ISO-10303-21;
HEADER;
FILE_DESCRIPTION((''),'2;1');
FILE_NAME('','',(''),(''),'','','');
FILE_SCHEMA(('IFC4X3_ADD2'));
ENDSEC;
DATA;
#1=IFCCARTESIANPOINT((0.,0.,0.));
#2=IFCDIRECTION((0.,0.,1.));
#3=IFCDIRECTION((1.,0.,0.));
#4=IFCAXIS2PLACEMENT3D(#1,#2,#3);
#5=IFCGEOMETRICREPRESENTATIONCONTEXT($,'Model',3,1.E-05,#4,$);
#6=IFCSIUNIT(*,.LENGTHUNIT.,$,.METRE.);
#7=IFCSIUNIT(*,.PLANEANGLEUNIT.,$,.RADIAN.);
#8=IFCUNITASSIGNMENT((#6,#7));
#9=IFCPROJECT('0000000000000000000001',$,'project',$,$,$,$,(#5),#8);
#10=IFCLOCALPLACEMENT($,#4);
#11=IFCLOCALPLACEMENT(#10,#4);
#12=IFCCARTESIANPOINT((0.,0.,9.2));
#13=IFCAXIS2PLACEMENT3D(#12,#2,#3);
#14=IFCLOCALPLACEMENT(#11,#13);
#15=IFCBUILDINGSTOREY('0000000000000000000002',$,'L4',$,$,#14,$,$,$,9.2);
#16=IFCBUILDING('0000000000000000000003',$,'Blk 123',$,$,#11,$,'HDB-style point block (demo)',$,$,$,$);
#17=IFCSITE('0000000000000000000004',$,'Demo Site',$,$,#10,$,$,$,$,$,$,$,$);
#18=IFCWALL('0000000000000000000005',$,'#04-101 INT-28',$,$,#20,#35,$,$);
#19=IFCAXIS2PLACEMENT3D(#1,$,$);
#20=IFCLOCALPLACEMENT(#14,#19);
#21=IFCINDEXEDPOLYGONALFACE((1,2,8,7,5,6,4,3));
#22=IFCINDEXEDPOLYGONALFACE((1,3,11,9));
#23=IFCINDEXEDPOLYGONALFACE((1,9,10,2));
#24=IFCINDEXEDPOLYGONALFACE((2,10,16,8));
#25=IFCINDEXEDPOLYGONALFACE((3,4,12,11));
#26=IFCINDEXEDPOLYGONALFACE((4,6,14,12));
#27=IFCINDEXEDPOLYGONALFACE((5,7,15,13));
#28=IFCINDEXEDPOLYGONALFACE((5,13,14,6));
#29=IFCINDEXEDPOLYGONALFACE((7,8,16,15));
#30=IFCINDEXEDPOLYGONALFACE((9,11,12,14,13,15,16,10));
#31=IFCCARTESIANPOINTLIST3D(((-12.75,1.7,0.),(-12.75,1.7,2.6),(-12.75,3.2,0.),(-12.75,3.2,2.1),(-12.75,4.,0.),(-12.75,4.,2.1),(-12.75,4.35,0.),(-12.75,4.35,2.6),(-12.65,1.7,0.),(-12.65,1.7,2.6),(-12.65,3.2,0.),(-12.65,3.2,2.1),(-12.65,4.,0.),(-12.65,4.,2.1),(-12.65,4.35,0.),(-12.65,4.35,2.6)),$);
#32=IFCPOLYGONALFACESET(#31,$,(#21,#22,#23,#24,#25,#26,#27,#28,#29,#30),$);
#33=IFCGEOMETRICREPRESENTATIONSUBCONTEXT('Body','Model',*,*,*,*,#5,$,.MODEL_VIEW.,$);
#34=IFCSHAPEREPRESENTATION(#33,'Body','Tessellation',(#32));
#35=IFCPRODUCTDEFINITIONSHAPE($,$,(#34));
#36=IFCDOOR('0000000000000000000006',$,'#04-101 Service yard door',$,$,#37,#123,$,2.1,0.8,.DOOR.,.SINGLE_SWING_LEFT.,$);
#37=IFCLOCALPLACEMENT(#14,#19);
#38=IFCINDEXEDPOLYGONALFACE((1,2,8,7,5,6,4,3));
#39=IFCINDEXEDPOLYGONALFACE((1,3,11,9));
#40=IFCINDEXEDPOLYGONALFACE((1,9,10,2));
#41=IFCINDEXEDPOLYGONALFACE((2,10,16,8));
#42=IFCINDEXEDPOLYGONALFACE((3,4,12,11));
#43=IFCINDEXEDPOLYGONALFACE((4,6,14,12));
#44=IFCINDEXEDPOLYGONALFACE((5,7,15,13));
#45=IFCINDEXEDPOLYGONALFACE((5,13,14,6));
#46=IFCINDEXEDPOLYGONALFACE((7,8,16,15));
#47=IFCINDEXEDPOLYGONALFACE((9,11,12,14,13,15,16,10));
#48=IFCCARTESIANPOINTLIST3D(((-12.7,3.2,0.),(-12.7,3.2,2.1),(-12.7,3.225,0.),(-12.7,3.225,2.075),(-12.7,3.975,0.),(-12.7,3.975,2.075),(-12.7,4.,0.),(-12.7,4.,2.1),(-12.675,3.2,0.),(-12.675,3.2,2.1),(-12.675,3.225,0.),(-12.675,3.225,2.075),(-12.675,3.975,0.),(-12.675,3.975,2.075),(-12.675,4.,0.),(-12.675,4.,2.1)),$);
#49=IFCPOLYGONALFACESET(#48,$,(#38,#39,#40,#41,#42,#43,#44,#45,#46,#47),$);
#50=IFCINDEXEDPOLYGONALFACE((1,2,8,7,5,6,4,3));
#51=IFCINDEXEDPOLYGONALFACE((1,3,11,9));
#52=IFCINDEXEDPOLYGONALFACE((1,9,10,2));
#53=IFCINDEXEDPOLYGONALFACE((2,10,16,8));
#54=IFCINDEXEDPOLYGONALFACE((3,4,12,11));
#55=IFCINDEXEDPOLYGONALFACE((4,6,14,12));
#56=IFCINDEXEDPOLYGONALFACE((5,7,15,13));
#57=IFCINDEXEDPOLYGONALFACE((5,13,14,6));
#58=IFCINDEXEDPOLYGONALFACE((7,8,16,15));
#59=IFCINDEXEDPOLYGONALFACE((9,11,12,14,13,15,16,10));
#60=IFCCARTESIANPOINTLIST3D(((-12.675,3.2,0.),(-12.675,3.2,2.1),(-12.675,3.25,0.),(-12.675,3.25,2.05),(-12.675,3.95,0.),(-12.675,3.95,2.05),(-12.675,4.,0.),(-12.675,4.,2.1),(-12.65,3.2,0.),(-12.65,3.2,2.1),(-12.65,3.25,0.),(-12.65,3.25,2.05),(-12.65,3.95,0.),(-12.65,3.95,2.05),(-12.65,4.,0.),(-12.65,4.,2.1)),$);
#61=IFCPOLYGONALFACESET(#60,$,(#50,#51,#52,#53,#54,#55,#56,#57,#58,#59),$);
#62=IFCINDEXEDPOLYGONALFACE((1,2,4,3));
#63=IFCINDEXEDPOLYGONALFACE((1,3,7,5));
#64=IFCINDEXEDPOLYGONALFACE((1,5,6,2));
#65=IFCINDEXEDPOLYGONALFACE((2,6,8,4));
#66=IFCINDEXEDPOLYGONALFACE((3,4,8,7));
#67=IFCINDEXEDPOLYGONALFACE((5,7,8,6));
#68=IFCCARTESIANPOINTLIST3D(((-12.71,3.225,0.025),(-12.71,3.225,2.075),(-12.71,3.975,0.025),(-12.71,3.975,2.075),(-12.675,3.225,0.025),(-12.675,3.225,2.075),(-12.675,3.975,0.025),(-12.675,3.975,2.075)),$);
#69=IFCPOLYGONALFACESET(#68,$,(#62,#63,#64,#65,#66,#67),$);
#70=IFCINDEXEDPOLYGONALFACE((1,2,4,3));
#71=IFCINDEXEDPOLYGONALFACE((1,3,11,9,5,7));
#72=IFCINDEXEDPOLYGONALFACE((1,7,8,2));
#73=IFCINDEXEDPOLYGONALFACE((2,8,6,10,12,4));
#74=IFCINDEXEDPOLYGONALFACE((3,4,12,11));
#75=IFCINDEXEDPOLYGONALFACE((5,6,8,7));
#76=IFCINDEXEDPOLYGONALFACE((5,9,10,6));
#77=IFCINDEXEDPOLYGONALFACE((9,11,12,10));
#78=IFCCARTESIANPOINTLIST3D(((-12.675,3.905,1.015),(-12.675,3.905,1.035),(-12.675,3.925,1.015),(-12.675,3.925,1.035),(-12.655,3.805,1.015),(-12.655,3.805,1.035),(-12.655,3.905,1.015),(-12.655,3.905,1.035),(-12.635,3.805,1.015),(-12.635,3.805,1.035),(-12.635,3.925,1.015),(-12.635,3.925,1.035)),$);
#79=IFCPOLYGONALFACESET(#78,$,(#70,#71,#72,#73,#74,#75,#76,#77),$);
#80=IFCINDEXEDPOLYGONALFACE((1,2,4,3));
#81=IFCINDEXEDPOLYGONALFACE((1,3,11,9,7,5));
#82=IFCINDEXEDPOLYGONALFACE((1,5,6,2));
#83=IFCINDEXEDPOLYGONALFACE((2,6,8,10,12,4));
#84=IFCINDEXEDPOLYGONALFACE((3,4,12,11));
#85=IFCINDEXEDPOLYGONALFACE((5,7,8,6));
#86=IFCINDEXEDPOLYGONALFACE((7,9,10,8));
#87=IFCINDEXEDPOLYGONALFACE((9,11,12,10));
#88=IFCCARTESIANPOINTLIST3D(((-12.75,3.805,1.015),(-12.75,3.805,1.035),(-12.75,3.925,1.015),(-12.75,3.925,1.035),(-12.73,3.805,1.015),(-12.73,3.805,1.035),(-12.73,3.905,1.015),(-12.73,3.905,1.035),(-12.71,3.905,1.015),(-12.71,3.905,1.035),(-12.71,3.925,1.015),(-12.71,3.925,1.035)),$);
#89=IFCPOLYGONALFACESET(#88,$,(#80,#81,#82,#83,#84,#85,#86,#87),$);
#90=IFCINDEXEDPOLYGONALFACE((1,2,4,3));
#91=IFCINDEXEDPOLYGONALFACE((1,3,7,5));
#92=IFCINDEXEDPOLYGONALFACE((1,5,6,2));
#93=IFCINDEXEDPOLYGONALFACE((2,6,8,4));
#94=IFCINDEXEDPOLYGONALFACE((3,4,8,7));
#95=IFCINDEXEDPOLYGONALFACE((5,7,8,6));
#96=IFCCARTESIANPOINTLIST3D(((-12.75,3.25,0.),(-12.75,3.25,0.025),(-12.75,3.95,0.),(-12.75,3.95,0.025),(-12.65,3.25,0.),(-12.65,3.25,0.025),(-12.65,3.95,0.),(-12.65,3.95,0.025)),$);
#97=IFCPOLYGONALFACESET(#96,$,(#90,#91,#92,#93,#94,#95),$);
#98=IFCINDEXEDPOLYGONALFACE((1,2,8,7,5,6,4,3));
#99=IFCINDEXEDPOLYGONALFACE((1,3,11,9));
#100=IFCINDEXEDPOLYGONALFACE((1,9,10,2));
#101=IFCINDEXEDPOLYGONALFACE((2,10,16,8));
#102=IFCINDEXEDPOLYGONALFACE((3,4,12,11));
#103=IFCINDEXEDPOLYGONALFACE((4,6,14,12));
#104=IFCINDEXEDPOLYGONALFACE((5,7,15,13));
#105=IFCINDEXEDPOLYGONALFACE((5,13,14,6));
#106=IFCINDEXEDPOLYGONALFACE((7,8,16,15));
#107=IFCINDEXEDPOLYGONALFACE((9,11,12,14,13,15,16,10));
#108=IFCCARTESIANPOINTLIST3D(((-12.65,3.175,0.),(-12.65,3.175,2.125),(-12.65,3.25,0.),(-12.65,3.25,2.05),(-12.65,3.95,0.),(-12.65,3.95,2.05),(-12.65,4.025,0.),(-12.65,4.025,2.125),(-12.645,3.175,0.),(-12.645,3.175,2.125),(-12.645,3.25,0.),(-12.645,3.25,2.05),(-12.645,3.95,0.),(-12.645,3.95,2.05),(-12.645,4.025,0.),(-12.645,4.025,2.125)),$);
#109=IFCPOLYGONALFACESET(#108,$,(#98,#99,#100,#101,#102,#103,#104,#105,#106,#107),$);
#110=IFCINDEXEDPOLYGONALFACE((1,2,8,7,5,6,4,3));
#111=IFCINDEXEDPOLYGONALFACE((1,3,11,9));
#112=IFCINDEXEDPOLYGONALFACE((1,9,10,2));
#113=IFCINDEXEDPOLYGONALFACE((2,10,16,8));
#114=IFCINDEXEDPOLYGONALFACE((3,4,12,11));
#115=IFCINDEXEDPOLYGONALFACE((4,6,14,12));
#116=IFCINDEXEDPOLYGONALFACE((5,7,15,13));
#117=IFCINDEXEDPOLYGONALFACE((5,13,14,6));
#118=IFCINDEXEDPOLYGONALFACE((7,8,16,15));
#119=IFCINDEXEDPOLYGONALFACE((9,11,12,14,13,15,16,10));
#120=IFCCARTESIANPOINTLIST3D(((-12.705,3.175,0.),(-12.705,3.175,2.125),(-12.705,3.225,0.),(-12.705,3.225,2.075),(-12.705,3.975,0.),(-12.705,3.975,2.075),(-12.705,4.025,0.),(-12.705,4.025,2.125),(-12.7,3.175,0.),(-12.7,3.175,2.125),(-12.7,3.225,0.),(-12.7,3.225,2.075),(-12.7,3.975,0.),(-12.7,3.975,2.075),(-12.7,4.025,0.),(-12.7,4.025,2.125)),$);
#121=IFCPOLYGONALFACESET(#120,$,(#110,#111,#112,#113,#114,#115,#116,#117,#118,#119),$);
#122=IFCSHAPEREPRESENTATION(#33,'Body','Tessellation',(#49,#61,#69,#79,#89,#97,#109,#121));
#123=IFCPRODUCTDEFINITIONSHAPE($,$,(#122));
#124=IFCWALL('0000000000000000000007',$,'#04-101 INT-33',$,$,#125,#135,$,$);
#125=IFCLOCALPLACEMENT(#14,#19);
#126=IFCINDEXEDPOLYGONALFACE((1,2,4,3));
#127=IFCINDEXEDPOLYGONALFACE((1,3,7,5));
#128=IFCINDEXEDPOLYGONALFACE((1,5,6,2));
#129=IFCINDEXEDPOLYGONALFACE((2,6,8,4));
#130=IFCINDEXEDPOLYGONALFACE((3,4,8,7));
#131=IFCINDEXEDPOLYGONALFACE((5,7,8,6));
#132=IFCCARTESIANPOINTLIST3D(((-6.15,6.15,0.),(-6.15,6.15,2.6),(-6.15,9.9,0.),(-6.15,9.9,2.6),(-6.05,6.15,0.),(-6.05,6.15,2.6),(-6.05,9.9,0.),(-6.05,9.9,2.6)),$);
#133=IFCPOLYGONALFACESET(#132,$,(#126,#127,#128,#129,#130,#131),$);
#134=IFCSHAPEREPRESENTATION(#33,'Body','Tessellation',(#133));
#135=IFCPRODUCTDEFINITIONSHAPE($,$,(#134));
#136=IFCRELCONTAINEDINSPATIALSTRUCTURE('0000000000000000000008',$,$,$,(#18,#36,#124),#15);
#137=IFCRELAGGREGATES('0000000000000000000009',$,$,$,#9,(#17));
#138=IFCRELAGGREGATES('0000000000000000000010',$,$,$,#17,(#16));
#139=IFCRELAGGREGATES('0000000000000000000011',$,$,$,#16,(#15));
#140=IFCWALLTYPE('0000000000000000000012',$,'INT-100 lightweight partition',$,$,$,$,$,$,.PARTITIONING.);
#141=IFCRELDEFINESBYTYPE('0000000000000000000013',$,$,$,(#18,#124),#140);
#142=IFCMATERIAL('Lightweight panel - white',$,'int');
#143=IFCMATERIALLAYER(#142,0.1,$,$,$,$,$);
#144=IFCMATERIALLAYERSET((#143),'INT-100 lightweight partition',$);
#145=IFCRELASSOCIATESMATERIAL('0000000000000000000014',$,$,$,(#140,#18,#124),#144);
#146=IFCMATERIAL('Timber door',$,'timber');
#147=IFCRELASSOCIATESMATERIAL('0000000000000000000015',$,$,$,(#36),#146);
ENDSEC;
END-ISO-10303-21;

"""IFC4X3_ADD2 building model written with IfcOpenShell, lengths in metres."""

from ifc_helpers import new_model, si_unit, frame, origin_with_axes, place, context, subcontext, project, spatial, line, indexed_curve, outline, extrude, material, layer, layer_set, layer_usage, type_object, element, fill, save


model = new_model("IFC4X3_ADD2")

# Units and contexts
model_context = context("Model", 3, precision=1e-05, world=origin_with_axes())
body_context = subcontext(model_context, "Body", "Model", "MODEL_VIEW")
ifc_project = project(units=[si_unit("LENGTHUNIT", "METRE"), si_unit("PLANEANGLEUNIT", "RADIAN")], contexts=[model_context])

# Site, building, storey
site_placement = place(None, origin_with_axes())
site = spatial("IfcSite", under=ifc_project, at=site_placement, Name="Demo Site")
building_placement = place(site_placement, origin_with_axes())
building = spatial("IfcBuilding", under=site, at=building_placement, Name="Blk 123", LongName="HDB-style point block (demo)")
storey_placement = place(building_placement, frame((0.0, 0.0, 9.2), z_axis=(0.0, 0.0, 1.0), x_axis=(1.0, 0.0, 0.0)))
storey = spatial("IfcBuildingStorey", under=building, at=storey_placement, Name="L4", Elevation=9.2)

# Shared definitions
ifc_material_1 = material(Name="Timber door", Category="timber")

# Shared definitions
ifc_material_2 = material(Name="Lightweight panel - white", Category="int")
ifc_layer_1 = layer(ifc_material_2, 0.1)
ifc_layer_set_1 = layer_set([ifc_layer_1], Name="INT-100 lightweight partition")
ifc_layer_usage_1 = layer_usage(ifc_layer_set_1, "AXIS2", "POSITIVE", -0.05)
wall_type_1 = type_object("IfcWallType", Name="INT-100 lightweight partition", PredefinedType="PARTITIONING", material=ifc_layer_set_1)

# Wall, opening, door
wall_1_placement = place(storey_placement, frame((-12.7, 1.7, 0.0), z_axis=(0.0, 0.0, 1.0), x_axis=(0.0, 1.0, 0.0)))
wall_1 = element("IfcWall", 1, at=wall_1_placement, inside=storey, type_object=wall_type_1, material=ifc_layer_usage_1, Name="#04-101 INT-28", context=body_context, shape_type="SweptSolid", body=[
    extrude(outline(indexed_curve([(0.0, 0.0), (0.0, 0.1), (2.65, 0.1), (2.65, 0.0), (0.0, 0.0)], self_intersect=False)), frame((0.0, -0.05, 0.0), z_axis=(0.0, 0.0, 1.0), x_axis=(1.0, 0.0, 0.0)), (0.0, 0.0, 1.0), 2.6),
])
opening_1_placement = place(wall_1_placement, frame((1.5, -0.15, 0.0), z_axis=(0.0, 0.0, 1.0), x_axis=(1.0, 0.0, 0.0)))
opening_1 = element("IfcOpeningElement", 2, at=opening_1_placement, cuts=wall_1, context=body_context, shape_type="SweptSolid", body=[
    extrude(outline(indexed_curve([(0.0, 0.0), (0.0, 0.3), (0.8, 0.3), (0.8, 0.0), (0.0, 0.0)], self_intersect=False)), origin_with_axes(), (0.0, 0.0, 1.0), 2.1),
])
door_1_placement = place(opening_1_placement, frame((0.0, 0.1, 0.0), z_axis=(0.0, 0.0, 1.0), x_axis=(1.0, 0.0, 0.0)))
door_1 = element("IfcDoor", 3, at=door_1_placement, inside=storey, material=ifc_material_1, Name="#04-101 Service yard door", OperationType="SINGLE_SWING_LEFT", OverallHeight=2.1, OverallWidth=0.8, PredefinedType="DOOR", context=body_context, shape_type="SweptSolid", body=[
    extrude(outline(indexed_curve([(0.0, 0.0), (0.0, 2.1), (0.8, 2.1), (0.8, 0.0), (0.775, 0.0), (0.775, 2.075), (0.025, 2.075), (0.025, 0.0)], segments=[line(1, 2, 3, 4, 5, 6, 7, 8, 1)])), frame((0.0, 0.025, 0.0), z_axis=(0.0, -1.0, 0.0), x_axis=(1.0, 0.0, 0.0)), (0.0, 0.0, -1.0), 0.025),
    extrude(outline(indexed_curve([(0.0, 0.0), (0.0, 2.1), (0.8, 2.1), (0.8, 0.0), (0.75, 0.0), (0.75, 2.05), (0.05, 2.05), (0.05, 0.0)], segments=[line(1, 2, 3, 4, 5, 6, 7, 8, 1)])), frame((0.0, 0.0, 0.0), z_axis=(0.0, -1.0, 0.0), x_axis=(1.0, 0.0, 0.0)), (0.0, 0.0, -1.0), 0.025),
    extrude(outline(indexed_curve([(0.0, 0.0), (0.75, 0.0), (0.75, 0.035), (0.0, 0.035)], segments=[line(1, 2, 3, 4, 1)])), frame((0.025, 0.025, 0.025), z_axis=(0.0, 0.0, 1.0), x_axis=(1.0, 0.0, 0.0)), (0.0, 0.0, 1.0), 2.05),
    extrude(outline(indexed_curve([(0.0, 0.0), (0.0, -0.04), (-0.12, -0.04), (-0.12, -0.02), (-0.02, -0.02), (-0.02, 0.0)], segments=[line(1, 2, 3, 4, 5, 6, 1)])), frame((0.725, 0.025, 1.015), z_axis=(0.0, 0.0, 1.0), x_axis=(1.0, 0.0, 0.0)), (0.0, 0.0, 1.0), 0.02),
    extrude(outline(indexed_curve([(0.0, 0.0), (0.0, 0.04), (-0.12, 0.04), (-0.12, 0.02), (-0.02, 0.02), (-0.02, 0.0)], segments=[line(1, 2, 3, 4, 5, 6, 1)])), frame((0.725, 0.06, 1.015), z_axis=(0.0, 0.0, 1.0), x_axis=(1.0, 0.0, 0.0)), (0.0, 0.0, 1.0), 0.02),
    extrude(outline(indexed_curve([(0.0, 0.0), (0.7, 0.0), (0.7, 0.1), (0.0, 0.1)], segments=[line(1, 2, 3, 4, 1)])), frame((0.05, 0.0, 0.0), z_axis=(0.0, 0.0, 1.0), x_axis=(1.0, 0.0, 0.0)), (0.0, 0.0, 1.0), 0.025),
    extrude(outline(indexed_curve([(0.0, 0.0), (0.0, 2.125), (0.85, 2.125), (0.85, 0.0), (0.775, 0.0), (0.775, 2.05), (0.075, 2.05), (0.075, 0.0)], segments=[line(1, 2, 3, 4, 5, 6, 7, 8, 1)])), frame((-0.025, -0.005, 0.0), z_axis=(0.0, -1.0, 0.0), x_axis=(1.0, 0.0, 0.0)), (0.0, 0.0, -1.0), 0.005),
    extrude(outline(indexed_curve([(0.0, 0.0), (0.0, 2.125), (0.85, 2.125), (0.85, 0.0), (0.8, 0.0), (0.8, 2.075), (0.05, 2.075), (0.05, 0.0)], segments=[line(1, 2, 3, 4, 5, 6, 7, 8, 1)])), frame((-0.025, 0.05, 0.0), z_axis=(0.0, -1.0, 0.0), x_axis=(1.0, 0.0, 0.0)), (0.0, 0.0, -1.0), 0.005),
])
fill(opening_1, door_1)

# Wall
wall_2_placement = place(storey_placement, frame((-6.1, 6.15, 0.0), z_axis=(0.0, 0.0, 1.0), x_axis=(0.0, 1.0, 0.0)))
element("IfcWall", 4, at=wall_2_placement, inside=storey, type_object=wall_type_1, material=ifc_layer_usage_1, Name="#04-101 INT-33", context=body_context, shape_type="SweptSolid", body=[
    extrude(outline(indexed_curve([(0.0, 0.0), (0.0, 0.1), (3.75, 0.1), (3.75, 0.0), (0.0, 0.0)], self_intersect=False)), frame((0.0, -0.05, 0.0), z_axis=(0.0, 0.0, 1.0), x_axis=(1.0, 0.0, 0.0)), (0.0, 0.0, 1.0), 2.6),
])

save(model, "model.ifc")
